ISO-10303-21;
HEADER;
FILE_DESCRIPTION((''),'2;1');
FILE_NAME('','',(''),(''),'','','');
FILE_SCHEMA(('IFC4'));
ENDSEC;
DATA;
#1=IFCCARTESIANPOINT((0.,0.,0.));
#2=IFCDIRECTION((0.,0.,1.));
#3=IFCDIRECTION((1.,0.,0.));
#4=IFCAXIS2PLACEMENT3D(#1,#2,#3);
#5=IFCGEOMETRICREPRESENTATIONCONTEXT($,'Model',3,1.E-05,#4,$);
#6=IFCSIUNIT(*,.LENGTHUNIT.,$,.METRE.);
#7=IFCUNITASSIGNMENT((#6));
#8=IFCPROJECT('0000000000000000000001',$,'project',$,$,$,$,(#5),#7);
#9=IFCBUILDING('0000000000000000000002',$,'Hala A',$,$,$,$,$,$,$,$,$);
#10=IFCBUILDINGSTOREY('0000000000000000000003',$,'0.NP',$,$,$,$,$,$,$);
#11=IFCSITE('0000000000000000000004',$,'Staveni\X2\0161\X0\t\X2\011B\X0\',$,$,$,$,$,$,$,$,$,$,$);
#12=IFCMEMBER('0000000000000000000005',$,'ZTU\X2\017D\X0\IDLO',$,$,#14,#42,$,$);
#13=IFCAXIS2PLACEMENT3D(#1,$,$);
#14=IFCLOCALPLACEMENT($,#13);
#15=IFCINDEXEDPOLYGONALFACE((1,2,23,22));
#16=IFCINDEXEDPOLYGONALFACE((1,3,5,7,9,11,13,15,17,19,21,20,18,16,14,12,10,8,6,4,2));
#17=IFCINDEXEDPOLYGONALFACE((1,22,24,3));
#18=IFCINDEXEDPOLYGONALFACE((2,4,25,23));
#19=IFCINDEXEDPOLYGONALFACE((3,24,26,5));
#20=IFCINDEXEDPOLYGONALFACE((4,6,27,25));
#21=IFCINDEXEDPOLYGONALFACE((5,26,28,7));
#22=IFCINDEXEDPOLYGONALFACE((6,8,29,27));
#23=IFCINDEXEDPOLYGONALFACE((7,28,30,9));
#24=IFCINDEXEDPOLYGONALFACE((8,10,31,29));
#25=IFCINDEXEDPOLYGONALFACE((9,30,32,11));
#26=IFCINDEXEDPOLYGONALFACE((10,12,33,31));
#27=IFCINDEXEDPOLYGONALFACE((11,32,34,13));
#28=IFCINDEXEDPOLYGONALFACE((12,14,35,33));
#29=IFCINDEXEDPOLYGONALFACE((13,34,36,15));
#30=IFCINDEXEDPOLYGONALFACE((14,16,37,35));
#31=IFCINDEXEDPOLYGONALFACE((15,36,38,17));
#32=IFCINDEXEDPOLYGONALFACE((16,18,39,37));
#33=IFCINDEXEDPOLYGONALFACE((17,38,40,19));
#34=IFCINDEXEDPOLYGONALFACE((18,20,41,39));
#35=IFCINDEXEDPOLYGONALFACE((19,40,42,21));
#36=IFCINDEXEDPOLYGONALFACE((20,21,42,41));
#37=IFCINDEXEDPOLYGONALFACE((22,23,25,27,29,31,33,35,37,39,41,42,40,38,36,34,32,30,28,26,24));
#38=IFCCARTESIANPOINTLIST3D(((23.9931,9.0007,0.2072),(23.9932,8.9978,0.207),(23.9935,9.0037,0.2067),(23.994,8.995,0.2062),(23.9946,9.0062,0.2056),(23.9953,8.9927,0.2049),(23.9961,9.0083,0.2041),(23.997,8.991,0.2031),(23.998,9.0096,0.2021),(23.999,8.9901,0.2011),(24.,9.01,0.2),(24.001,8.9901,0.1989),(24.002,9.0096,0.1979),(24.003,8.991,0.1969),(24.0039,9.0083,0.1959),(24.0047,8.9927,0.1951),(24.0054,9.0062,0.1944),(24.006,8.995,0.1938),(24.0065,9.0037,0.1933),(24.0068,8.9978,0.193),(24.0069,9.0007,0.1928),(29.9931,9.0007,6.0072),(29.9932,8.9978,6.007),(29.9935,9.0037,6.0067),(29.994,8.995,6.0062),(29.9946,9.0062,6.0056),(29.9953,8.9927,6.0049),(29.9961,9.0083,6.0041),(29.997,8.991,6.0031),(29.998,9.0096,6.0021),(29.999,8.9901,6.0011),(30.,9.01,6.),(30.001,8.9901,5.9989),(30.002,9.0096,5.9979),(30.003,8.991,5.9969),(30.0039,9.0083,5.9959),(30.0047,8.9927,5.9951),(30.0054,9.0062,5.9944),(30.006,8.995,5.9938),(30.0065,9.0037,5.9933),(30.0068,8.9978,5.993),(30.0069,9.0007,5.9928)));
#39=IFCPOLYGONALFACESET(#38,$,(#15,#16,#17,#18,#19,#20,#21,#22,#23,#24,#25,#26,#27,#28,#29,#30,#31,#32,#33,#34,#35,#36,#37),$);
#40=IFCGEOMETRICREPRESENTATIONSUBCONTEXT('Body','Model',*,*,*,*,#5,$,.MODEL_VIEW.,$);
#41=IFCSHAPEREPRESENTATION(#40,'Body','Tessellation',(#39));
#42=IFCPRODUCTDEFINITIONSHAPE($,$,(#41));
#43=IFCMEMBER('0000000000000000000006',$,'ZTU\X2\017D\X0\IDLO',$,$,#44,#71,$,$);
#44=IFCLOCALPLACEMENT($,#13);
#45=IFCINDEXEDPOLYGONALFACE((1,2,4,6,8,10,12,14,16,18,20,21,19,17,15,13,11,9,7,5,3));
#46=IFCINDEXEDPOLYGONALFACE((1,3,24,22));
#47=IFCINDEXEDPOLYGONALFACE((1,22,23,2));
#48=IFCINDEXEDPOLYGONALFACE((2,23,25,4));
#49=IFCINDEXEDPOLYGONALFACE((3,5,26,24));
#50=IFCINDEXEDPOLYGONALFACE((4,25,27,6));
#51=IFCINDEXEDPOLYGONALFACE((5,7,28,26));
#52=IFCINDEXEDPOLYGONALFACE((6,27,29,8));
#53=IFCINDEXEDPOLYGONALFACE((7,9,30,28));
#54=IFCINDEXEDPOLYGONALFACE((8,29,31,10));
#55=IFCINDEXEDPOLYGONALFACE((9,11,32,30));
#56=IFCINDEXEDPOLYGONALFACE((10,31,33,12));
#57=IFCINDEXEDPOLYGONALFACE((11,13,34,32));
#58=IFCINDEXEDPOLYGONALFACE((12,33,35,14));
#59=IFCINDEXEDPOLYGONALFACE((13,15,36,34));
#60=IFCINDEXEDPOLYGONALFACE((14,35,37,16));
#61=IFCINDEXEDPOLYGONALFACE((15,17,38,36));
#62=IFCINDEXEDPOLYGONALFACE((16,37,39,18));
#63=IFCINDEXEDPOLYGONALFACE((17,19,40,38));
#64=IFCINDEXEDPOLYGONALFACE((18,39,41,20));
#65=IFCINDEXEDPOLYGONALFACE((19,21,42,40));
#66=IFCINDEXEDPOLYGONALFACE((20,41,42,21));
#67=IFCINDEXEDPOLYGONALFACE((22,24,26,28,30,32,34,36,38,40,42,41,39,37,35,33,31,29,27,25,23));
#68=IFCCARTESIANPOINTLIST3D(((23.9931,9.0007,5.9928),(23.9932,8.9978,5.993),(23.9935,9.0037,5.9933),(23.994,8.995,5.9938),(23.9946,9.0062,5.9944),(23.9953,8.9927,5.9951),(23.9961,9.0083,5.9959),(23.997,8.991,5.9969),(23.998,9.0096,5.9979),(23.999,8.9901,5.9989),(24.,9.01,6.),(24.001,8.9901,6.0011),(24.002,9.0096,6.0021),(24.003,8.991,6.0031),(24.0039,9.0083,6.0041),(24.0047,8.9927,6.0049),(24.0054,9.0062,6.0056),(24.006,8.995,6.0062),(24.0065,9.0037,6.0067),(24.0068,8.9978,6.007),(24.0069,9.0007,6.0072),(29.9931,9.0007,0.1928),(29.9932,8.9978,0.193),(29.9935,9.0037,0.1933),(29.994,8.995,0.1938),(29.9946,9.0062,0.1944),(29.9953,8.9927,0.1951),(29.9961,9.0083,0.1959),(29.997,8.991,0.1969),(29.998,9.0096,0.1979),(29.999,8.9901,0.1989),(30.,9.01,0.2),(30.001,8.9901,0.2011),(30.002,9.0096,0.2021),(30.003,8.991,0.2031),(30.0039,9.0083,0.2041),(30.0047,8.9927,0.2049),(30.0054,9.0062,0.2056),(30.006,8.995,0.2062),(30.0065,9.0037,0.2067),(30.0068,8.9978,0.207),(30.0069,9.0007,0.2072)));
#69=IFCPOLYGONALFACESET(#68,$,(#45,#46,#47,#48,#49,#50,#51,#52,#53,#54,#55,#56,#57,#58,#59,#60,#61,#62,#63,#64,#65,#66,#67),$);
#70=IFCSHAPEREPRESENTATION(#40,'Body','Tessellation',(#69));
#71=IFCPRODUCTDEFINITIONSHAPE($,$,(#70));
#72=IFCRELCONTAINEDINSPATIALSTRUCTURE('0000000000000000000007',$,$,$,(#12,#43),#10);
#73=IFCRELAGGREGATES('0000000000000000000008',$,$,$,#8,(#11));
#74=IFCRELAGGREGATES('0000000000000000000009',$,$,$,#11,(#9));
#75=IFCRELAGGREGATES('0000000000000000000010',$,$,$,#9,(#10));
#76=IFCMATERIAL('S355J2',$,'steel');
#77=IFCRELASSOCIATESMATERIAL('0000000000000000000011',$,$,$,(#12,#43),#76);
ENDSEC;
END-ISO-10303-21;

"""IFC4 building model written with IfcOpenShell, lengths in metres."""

from ifc_helpers import new_model, si_unit, frame, origin_with_axes, place, context, subcontext, project, spatial, circle, extrude, material, element, save


model = new_model("IFC4")

# Units and contexts
model_context = context("Model", 3, precision=1e-05, world=origin_with_axes())
body_context = subcontext(model_context, "Body", "Model", "MODEL_VIEW")
ifc_project = project(units=[si_unit("LENGTHUNIT", "METRE")], contexts=[model_context])

# Site, building, storey
site = spatial("IfcSite", under=ifc_project, Name="Staveniště")
building = spatial("IfcBuilding", under=site, Name="Hala A")
storey = spatial("IfcBuildingStorey", under=building, Name="0.NP")

# Shared definitions
ifc_material_1 = material(Name="S355J2", Category="steel")

# Members
for number, where, z_axis, x_axis, name in (
    (1, (24.0, 9.0, 0.2), (0.718988, 0.0, 0.695022), (0.0, 1.0, 0.0), "ZTUŽIDLO"),
    (2, (24.0, 9.0, 6.0), (0.718988, 0.0, -0.695022), (0.0, 1.0, 0.0), "ZTUŽIDLO"),
):
    element("IfcMember", number, at=place(None, frame(where, z_axis=z_axis, x_axis=x_axis)), inside=storey, material=ifc_material_1, Name=name, context=body_context, shape_type="SweptSolid", body=[
        extrude(circle(Radius=0.01), origin_with_axes(), (0.0, 0.0, 1.0), 8.3451),
    ])

save(model, "model.ifc")
